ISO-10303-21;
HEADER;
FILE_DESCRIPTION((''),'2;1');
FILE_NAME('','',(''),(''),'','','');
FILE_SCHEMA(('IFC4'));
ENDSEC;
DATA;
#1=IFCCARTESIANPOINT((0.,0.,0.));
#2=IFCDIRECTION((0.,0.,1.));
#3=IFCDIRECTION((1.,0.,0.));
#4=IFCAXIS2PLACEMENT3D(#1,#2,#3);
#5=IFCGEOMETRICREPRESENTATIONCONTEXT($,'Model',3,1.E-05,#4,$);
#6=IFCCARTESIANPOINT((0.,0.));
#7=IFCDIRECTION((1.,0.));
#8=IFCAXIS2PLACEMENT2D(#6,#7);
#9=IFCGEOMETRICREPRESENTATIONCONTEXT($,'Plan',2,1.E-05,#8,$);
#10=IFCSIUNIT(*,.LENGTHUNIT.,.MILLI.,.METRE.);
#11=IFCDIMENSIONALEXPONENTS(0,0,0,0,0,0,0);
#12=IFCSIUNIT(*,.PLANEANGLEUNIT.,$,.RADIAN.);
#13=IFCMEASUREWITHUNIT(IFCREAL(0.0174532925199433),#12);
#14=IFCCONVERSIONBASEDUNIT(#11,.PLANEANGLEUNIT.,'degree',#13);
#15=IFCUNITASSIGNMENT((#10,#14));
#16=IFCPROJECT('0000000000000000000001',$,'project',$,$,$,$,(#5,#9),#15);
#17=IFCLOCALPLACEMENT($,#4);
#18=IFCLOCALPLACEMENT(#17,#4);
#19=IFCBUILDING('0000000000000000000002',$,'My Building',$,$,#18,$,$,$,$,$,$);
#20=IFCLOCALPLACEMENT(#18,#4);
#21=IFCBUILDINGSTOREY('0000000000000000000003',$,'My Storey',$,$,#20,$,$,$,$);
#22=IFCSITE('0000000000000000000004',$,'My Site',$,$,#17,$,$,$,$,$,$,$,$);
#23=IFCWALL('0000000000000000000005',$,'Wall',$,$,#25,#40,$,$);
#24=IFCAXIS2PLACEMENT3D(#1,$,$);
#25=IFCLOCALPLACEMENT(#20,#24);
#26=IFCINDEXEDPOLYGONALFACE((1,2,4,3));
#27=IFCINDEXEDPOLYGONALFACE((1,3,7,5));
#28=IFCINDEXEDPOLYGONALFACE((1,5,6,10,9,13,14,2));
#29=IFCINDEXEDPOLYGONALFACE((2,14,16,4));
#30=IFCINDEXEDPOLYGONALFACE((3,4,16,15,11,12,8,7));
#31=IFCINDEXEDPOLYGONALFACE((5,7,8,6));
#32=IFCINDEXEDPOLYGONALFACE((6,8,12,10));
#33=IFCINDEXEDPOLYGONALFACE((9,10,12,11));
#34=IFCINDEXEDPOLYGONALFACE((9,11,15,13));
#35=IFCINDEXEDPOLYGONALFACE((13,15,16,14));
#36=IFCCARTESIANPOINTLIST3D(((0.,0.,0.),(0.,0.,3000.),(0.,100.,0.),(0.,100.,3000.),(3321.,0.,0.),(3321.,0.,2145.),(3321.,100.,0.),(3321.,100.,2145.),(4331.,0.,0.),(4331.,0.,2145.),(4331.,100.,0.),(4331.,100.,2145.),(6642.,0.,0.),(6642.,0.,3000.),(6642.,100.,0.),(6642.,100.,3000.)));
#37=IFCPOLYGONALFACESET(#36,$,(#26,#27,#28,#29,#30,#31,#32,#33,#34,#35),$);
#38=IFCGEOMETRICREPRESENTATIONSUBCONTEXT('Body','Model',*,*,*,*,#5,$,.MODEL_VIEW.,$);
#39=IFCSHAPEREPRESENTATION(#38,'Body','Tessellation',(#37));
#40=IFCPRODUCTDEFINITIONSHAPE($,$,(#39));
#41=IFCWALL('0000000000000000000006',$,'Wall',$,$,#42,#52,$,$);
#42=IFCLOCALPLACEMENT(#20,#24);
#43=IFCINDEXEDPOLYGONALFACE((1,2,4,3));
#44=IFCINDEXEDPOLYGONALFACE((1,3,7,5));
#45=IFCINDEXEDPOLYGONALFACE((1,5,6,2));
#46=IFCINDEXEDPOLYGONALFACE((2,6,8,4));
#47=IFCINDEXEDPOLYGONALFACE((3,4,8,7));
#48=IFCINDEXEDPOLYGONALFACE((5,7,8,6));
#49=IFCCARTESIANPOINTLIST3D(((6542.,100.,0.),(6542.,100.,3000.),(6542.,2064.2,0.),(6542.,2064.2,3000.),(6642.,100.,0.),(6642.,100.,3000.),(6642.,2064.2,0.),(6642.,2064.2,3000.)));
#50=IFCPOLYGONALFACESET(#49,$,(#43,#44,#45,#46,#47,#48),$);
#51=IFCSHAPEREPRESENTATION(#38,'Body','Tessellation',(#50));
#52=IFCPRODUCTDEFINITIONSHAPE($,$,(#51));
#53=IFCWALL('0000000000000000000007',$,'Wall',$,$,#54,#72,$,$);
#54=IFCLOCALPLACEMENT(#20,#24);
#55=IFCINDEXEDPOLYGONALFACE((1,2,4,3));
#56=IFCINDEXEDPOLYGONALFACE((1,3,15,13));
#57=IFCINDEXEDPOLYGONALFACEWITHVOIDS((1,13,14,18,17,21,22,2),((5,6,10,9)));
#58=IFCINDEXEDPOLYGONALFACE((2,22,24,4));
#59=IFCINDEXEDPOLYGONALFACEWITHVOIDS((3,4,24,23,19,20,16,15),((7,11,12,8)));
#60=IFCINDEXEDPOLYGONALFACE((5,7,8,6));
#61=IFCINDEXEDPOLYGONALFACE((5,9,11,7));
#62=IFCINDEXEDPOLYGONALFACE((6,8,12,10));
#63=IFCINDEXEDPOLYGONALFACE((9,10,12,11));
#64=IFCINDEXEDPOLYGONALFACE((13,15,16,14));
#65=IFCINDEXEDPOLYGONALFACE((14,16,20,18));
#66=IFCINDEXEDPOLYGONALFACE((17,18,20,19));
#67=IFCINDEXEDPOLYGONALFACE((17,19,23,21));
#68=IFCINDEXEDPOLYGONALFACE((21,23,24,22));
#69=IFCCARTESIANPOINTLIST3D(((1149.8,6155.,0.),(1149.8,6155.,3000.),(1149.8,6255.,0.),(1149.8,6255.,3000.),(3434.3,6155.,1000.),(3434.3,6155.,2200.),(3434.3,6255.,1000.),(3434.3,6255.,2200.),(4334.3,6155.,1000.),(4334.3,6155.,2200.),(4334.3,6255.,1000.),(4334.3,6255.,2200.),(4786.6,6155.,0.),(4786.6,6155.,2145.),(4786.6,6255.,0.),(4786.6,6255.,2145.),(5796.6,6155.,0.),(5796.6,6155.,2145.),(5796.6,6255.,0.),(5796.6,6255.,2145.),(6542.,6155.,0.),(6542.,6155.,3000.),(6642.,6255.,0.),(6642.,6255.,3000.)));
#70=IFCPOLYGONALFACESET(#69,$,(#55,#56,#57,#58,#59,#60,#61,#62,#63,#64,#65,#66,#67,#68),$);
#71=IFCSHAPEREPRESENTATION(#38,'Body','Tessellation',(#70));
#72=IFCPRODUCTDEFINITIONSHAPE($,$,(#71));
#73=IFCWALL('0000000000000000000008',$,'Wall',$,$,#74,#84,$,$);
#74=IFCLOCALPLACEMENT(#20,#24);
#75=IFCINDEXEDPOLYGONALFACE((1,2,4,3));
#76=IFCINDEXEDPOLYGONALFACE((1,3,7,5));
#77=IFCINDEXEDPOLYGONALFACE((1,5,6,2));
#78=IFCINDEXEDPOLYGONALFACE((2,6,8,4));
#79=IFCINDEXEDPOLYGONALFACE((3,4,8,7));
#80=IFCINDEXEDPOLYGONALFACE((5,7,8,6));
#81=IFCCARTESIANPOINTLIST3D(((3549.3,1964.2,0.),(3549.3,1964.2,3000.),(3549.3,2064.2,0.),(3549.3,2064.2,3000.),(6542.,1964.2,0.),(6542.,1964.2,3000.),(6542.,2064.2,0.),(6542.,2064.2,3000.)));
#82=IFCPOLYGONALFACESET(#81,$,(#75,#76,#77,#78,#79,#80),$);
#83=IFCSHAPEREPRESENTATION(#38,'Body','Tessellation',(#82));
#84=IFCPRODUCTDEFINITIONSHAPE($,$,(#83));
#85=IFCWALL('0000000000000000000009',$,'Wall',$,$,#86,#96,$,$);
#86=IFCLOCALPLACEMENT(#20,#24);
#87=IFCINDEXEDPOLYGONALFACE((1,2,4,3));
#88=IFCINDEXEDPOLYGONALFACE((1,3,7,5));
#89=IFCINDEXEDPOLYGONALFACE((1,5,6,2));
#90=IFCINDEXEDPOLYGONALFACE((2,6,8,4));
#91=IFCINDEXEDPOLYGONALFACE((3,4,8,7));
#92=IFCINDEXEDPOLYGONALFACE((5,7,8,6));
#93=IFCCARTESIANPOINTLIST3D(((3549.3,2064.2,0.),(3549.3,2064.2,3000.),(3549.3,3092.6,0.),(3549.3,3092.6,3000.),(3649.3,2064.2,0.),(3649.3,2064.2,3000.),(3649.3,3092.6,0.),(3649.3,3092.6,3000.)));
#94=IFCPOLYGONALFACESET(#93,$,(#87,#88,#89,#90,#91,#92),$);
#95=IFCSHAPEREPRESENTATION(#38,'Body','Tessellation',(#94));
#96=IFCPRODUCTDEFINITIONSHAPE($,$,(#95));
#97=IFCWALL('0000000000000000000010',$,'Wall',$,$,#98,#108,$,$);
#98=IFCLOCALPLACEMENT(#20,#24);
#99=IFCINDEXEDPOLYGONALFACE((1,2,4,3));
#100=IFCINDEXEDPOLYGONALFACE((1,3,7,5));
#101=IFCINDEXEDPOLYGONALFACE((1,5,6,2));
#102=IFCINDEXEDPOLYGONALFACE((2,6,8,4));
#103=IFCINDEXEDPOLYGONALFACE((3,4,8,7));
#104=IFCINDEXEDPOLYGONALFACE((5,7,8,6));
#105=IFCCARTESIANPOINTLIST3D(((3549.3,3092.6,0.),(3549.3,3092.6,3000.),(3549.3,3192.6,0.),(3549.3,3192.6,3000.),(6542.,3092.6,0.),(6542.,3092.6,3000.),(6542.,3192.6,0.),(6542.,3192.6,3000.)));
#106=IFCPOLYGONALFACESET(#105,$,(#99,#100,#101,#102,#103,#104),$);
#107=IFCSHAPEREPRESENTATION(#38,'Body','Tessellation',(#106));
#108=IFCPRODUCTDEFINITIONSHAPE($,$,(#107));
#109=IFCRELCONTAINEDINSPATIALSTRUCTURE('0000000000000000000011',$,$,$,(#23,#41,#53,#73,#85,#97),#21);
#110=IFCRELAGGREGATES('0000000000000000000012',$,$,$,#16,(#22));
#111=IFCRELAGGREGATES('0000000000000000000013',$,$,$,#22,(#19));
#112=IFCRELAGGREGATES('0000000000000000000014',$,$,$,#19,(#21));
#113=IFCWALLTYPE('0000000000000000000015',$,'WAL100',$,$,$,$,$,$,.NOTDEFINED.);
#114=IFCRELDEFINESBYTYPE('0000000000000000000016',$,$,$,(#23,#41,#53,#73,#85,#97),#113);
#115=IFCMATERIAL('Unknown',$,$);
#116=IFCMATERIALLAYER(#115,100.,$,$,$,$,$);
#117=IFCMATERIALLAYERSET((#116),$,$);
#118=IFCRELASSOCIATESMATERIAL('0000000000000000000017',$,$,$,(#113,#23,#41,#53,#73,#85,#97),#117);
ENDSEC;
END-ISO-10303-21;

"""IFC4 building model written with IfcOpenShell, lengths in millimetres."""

from ifc_helpers import new_model, entity, si_unit, converted_unit, frame, origin_with_axes, origin_2d_with_axis, place, context, subcontext, project, spatial, line, indexed_curve, outline, extrude, clip, halfspace, source, transform, mapped, material, layer, layer_set, layer_usage, type_object, element, save


model = new_model("IFC4")

# Units and contexts
model_context = context("Model", 3, precision=1e-05, world=origin_with_axes())
plan_context = context("Plan", 2, precision=1e-05, world=origin_2d_with_axis())
body_context = subcontext(model_context, "Body", "Model", "MODEL_VIEW")
ifc_project = project(units=[si_unit("LENGTHUNIT", "METRE", prefix="MILLI"), converted_unit("PLANEANGLEUNIT", "degree", entity("IfcReal", 0.0174532925199433), si_unit("PLANEANGLEUNIT", "RADIAN"), dimensions=[0, 0, 0, 0, 0, 0, 0])], contexts=[model_context, plan_context])

# Site, building, storey
site_placement = place(None, origin_with_axes())
site = spatial("IfcSite", under=ifc_project, at=site_placement, Name="My Site")
building_placement = place(site_placement, origin_with_axes())
building = spatial("IfcBuilding", under=site, at=building_placement, Name="My Building")
storey_placement = place(building_placement, origin_with_axes())
storey = spatial("IfcBuildingStorey", under=building, at=storey_placement, Name="My Storey")

# Wall, opening
ifc_material = material(Name="Unknown")
ifc_layer = layer(ifc_material, 100.0)
ifc_layer_set = layer_set([ifc_layer])
ifc_layer_usage_1 = layer_usage(ifc_layer_set, "AXIS2", "POSITIVE", 0.0)
wall_type = type_object("IfcWallType", Name="WAL100", PredefinedType="NOTDEFINED", material=ifc_layer_set)
wall_1_placement = place(storey_placement, origin_with_axes())
wall_1 = element("IfcWall", 1, at=wall_1_placement, inside=storey, type_object=wall_type, material=ifc_layer_usage_1, Name="Wall", context=body_context, shape_type="SweptSolid", body=[
    extrude(outline(indexed_curve([(0.0, 0.0), (0.0, 100.0), (6642.0, 100.0), (6642.0, 0.0), (0.0, 0.0)], self_intersect=False)), origin_with_axes(), (0.0, 0.0, 1.0), 3000.0),
])
shared_shape_1 = source(origin_with_axes(), body_context, "Body", "SweptSolid", [
    extrude(outline(indexed_curve([(0.0, 0.0), (1010.0, 0.0), (1010.0, 2145.0), (0.0, 2145.0)], segments=[line(1, 2, 3, 4, 1)])), frame((0.0, -100.0, 0.0), z_axis=(0.0, -1.0, 0.0), x_axis=(1.0, 0.0, 0.0)), (0.0, 0.0, -1.0), 300.0),
])
opening_1_placement = place(wall_1_placement, frame((3321.0, 0.0, 0.0), z_axis=(0.0, 0.0, 1.0), x_axis=(1.0, 0.0, 0.0)))
element("IfcOpeningElement", 2, at=opening_1_placement, cuts=wall_1, PredefinedType="OPENING", context=body_context, shape_type="MappedRepresentation", body=[
    mapped(shared_shape_1, transform((0.0, 0.0, 0.0), x_axis=(1.0, 0.0, 0.0), y_axis=(0.0, 1.0, 0.0), z_axis=(0.0, 0.0, 1.0), scale=1.0)),
])

# Wall
ifc_layer_usage_2 = layer_usage(ifc_layer_set, "AXIS2", "POSITIVE", 0.0)
wall_2_placement = place(storey_placement, frame((6642.0, 100.0, 0.0), z_axis=(0.0, 0.0, 1.0), x_axis=(0.0, 1.0, 0.0)))
element("IfcWall", 3, at=wall_2_placement, inside=storey, type_object=wall_type, material=ifc_layer_usage_2, Name="Wall", context=body_context, shape_type="SweptSolid", body=[
    extrude(outline(indexed_curve([(0.0, 0.0), (0.0, 100.0), (1964.2, 100.0), (1964.2, 0.0), (0.0, 0.0)], self_intersect=False)), origin_with_axes(), (0.0, 0.0, 1.0), 3000.0),
])

# Wall, openings
ifc_layer_usage_3 = layer_usage(ifc_layer_set, "AXIS2", "POSITIVE", 0.0)
wall_3_placement = place(storey_placement, frame((1149.8, 6155.0, 0.0), z_axis=(0.0, 0.0, 1.0), x_axis=(1.0, 0.0, 0.0)))
wall_3 = element("IfcWall", 4, at=wall_3_placement, inside=storey, type_object=wall_type, material=ifc_layer_usage_3, Name="Wall", context=body_context, shape_type="Clipping", body=[
    clip(extrude(outline(indexed_curve([(0.0, 0.0), (0.0, 100.0), (5492.2, 100.0), (5492.2, 0.0), (0.0, 0.0)], self_intersect=False)), origin_with_axes(), (0.0, 0.0, 1.0), 3000.0), halfspace(frame((5392.2, 0.0, 0.0), z_axis=(0.3, -0.3, 0.0), x_axis=(0.1, 0.1, 0.0)), False)),
])
opening_2_placement = place(wall_3_placement, frame((3636.8, 0.0, 0.0), z_axis=(0.0, 0.0, 1.0), x_axis=(1.0, 0.0, 0.0)))
element("IfcOpeningElement", 5, at=opening_2_placement, cuts=wall_3, PredefinedType="OPENING", context=body_context, shape_type="MappedRepresentation", body=[
    mapped(shared_shape_1, transform((0.0, 0.0, 0.0), x_axis=(1.0, 0.0, 0.0), y_axis=(0.0, 1.0, 0.0), z_axis=(0.0, 0.0, 1.0), scale=1.0)),
])
shared_shape_2 = source(origin_with_axes(), body_context, "Body", "SweptSolid", [
    extrude(outline(indexed_curve([(0.0, 0.0), (900.0, 0.0), (900.0, 1200.0), (0.0, 1200.0)], segments=[line(1, 2, 3, 4, 1)])), frame((0.0, -100.0, 0.0), z_axis=(0.0, -1.0, 0.0), x_axis=(1.0, 0.0, 0.0)), (0.0, 0.0, -1.0), 300.0),
])
opening_3_placement = place(wall_3_placement, frame((2284.5, 0.0, 1000.0), z_axis=(0.0, 0.0, 1.0), x_axis=(1.0, 0.0, 0.0)))
element("IfcOpeningElement", 6, at=opening_3_placement, cuts=wall_3, PredefinedType="OPENING", context=body_context, shape_type="MappedRepresentation", body=[
    mapped(shared_shape_2, transform((0.0, 0.0, 0.0), x_axis=(1.0, 0.0, 0.0), y_axis=(0.0, 1.0, 0.0), z_axis=(0.0, 0.0, 1.0), scale=1.0)),
])

# Walls
ifc_layer_usage_4 = layer_usage(ifc_layer_set, "AXIS2", "POSITIVE", 0.0)
wall_4_placement = place(storey_placement, frame((6542.0, 2064.2, 0.0), z_axis=(0.0, 0.0, 1.0), x_axis=(-1.0, 0.0, 0.0)))
element("IfcWall", 7, at=wall_4_placement, inside=storey, type_object=wall_type, material=ifc_layer_usage_4, Name="Wall", context=body_context, shape_type="SweptSolid", body=[
    extrude(outline(indexed_curve([(0.0, 0.0), (0.0, 100.0), (2992.6, 100.0), (2992.6, 0.0), (0.0, 0.0)], self_intersect=False)), origin_with_axes(), (0.0, 0.0, 1.0), 3000.0),
])
ifc_layer_usage_5 = layer_usage(ifc_layer_set, "AXIS2", "POSITIVE", 0.0)
wall_5_placement = place(storey_placement, frame((3549.3, 3092.6, 0.0), z_axis=(0.0, 0.0, 1.0), x_axis=(-0.000001, -1.0, 0.0)))
element("IfcWall", 8, at=wall_5_placement, inside=storey, type_object=wall_type, material=ifc_layer_usage_5, Name="Wall", context=body_context, shape_type="SweptSolid", body=[
    extrude(outline(indexed_curve([(0.0, 0.0), (0.0, 100.0), (1028.5, 100.0), (1028.5, 0.0), (0.0, 0.0)], self_intersect=False)), origin_with_axes(), (0.0, 0.0, 1.0), 3000.0),
])
ifc_layer_usage_6 = layer_usage(ifc_layer_set, "AXIS2", "POSITIVE", 0.0)
wall_6_placement = place(storey_placement, frame((3549.3, 3092.6, 0.0), z_axis=(0.0, 0.0, 1.0), x_axis=(1.0, -0.000001, 0.0)))
element("IfcWall", 9, at=wall_6_placement, inside=storey, type_object=wall_type, material=ifc_layer_usage_6, Name="Wall", context=body_context, shape_type="SweptSolid", body=[
    extrude(outline(indexed_curve([(0.0, 0.0), (0.0, 100.0), (2992.6, 100.0), (2992.6, 0.0), (0.0, 0.0)], self_intersect=False)), origin_with_axes(), (0.0, 0.0, 1.0), 3000.0),
])

save(model, "model.ifc")
